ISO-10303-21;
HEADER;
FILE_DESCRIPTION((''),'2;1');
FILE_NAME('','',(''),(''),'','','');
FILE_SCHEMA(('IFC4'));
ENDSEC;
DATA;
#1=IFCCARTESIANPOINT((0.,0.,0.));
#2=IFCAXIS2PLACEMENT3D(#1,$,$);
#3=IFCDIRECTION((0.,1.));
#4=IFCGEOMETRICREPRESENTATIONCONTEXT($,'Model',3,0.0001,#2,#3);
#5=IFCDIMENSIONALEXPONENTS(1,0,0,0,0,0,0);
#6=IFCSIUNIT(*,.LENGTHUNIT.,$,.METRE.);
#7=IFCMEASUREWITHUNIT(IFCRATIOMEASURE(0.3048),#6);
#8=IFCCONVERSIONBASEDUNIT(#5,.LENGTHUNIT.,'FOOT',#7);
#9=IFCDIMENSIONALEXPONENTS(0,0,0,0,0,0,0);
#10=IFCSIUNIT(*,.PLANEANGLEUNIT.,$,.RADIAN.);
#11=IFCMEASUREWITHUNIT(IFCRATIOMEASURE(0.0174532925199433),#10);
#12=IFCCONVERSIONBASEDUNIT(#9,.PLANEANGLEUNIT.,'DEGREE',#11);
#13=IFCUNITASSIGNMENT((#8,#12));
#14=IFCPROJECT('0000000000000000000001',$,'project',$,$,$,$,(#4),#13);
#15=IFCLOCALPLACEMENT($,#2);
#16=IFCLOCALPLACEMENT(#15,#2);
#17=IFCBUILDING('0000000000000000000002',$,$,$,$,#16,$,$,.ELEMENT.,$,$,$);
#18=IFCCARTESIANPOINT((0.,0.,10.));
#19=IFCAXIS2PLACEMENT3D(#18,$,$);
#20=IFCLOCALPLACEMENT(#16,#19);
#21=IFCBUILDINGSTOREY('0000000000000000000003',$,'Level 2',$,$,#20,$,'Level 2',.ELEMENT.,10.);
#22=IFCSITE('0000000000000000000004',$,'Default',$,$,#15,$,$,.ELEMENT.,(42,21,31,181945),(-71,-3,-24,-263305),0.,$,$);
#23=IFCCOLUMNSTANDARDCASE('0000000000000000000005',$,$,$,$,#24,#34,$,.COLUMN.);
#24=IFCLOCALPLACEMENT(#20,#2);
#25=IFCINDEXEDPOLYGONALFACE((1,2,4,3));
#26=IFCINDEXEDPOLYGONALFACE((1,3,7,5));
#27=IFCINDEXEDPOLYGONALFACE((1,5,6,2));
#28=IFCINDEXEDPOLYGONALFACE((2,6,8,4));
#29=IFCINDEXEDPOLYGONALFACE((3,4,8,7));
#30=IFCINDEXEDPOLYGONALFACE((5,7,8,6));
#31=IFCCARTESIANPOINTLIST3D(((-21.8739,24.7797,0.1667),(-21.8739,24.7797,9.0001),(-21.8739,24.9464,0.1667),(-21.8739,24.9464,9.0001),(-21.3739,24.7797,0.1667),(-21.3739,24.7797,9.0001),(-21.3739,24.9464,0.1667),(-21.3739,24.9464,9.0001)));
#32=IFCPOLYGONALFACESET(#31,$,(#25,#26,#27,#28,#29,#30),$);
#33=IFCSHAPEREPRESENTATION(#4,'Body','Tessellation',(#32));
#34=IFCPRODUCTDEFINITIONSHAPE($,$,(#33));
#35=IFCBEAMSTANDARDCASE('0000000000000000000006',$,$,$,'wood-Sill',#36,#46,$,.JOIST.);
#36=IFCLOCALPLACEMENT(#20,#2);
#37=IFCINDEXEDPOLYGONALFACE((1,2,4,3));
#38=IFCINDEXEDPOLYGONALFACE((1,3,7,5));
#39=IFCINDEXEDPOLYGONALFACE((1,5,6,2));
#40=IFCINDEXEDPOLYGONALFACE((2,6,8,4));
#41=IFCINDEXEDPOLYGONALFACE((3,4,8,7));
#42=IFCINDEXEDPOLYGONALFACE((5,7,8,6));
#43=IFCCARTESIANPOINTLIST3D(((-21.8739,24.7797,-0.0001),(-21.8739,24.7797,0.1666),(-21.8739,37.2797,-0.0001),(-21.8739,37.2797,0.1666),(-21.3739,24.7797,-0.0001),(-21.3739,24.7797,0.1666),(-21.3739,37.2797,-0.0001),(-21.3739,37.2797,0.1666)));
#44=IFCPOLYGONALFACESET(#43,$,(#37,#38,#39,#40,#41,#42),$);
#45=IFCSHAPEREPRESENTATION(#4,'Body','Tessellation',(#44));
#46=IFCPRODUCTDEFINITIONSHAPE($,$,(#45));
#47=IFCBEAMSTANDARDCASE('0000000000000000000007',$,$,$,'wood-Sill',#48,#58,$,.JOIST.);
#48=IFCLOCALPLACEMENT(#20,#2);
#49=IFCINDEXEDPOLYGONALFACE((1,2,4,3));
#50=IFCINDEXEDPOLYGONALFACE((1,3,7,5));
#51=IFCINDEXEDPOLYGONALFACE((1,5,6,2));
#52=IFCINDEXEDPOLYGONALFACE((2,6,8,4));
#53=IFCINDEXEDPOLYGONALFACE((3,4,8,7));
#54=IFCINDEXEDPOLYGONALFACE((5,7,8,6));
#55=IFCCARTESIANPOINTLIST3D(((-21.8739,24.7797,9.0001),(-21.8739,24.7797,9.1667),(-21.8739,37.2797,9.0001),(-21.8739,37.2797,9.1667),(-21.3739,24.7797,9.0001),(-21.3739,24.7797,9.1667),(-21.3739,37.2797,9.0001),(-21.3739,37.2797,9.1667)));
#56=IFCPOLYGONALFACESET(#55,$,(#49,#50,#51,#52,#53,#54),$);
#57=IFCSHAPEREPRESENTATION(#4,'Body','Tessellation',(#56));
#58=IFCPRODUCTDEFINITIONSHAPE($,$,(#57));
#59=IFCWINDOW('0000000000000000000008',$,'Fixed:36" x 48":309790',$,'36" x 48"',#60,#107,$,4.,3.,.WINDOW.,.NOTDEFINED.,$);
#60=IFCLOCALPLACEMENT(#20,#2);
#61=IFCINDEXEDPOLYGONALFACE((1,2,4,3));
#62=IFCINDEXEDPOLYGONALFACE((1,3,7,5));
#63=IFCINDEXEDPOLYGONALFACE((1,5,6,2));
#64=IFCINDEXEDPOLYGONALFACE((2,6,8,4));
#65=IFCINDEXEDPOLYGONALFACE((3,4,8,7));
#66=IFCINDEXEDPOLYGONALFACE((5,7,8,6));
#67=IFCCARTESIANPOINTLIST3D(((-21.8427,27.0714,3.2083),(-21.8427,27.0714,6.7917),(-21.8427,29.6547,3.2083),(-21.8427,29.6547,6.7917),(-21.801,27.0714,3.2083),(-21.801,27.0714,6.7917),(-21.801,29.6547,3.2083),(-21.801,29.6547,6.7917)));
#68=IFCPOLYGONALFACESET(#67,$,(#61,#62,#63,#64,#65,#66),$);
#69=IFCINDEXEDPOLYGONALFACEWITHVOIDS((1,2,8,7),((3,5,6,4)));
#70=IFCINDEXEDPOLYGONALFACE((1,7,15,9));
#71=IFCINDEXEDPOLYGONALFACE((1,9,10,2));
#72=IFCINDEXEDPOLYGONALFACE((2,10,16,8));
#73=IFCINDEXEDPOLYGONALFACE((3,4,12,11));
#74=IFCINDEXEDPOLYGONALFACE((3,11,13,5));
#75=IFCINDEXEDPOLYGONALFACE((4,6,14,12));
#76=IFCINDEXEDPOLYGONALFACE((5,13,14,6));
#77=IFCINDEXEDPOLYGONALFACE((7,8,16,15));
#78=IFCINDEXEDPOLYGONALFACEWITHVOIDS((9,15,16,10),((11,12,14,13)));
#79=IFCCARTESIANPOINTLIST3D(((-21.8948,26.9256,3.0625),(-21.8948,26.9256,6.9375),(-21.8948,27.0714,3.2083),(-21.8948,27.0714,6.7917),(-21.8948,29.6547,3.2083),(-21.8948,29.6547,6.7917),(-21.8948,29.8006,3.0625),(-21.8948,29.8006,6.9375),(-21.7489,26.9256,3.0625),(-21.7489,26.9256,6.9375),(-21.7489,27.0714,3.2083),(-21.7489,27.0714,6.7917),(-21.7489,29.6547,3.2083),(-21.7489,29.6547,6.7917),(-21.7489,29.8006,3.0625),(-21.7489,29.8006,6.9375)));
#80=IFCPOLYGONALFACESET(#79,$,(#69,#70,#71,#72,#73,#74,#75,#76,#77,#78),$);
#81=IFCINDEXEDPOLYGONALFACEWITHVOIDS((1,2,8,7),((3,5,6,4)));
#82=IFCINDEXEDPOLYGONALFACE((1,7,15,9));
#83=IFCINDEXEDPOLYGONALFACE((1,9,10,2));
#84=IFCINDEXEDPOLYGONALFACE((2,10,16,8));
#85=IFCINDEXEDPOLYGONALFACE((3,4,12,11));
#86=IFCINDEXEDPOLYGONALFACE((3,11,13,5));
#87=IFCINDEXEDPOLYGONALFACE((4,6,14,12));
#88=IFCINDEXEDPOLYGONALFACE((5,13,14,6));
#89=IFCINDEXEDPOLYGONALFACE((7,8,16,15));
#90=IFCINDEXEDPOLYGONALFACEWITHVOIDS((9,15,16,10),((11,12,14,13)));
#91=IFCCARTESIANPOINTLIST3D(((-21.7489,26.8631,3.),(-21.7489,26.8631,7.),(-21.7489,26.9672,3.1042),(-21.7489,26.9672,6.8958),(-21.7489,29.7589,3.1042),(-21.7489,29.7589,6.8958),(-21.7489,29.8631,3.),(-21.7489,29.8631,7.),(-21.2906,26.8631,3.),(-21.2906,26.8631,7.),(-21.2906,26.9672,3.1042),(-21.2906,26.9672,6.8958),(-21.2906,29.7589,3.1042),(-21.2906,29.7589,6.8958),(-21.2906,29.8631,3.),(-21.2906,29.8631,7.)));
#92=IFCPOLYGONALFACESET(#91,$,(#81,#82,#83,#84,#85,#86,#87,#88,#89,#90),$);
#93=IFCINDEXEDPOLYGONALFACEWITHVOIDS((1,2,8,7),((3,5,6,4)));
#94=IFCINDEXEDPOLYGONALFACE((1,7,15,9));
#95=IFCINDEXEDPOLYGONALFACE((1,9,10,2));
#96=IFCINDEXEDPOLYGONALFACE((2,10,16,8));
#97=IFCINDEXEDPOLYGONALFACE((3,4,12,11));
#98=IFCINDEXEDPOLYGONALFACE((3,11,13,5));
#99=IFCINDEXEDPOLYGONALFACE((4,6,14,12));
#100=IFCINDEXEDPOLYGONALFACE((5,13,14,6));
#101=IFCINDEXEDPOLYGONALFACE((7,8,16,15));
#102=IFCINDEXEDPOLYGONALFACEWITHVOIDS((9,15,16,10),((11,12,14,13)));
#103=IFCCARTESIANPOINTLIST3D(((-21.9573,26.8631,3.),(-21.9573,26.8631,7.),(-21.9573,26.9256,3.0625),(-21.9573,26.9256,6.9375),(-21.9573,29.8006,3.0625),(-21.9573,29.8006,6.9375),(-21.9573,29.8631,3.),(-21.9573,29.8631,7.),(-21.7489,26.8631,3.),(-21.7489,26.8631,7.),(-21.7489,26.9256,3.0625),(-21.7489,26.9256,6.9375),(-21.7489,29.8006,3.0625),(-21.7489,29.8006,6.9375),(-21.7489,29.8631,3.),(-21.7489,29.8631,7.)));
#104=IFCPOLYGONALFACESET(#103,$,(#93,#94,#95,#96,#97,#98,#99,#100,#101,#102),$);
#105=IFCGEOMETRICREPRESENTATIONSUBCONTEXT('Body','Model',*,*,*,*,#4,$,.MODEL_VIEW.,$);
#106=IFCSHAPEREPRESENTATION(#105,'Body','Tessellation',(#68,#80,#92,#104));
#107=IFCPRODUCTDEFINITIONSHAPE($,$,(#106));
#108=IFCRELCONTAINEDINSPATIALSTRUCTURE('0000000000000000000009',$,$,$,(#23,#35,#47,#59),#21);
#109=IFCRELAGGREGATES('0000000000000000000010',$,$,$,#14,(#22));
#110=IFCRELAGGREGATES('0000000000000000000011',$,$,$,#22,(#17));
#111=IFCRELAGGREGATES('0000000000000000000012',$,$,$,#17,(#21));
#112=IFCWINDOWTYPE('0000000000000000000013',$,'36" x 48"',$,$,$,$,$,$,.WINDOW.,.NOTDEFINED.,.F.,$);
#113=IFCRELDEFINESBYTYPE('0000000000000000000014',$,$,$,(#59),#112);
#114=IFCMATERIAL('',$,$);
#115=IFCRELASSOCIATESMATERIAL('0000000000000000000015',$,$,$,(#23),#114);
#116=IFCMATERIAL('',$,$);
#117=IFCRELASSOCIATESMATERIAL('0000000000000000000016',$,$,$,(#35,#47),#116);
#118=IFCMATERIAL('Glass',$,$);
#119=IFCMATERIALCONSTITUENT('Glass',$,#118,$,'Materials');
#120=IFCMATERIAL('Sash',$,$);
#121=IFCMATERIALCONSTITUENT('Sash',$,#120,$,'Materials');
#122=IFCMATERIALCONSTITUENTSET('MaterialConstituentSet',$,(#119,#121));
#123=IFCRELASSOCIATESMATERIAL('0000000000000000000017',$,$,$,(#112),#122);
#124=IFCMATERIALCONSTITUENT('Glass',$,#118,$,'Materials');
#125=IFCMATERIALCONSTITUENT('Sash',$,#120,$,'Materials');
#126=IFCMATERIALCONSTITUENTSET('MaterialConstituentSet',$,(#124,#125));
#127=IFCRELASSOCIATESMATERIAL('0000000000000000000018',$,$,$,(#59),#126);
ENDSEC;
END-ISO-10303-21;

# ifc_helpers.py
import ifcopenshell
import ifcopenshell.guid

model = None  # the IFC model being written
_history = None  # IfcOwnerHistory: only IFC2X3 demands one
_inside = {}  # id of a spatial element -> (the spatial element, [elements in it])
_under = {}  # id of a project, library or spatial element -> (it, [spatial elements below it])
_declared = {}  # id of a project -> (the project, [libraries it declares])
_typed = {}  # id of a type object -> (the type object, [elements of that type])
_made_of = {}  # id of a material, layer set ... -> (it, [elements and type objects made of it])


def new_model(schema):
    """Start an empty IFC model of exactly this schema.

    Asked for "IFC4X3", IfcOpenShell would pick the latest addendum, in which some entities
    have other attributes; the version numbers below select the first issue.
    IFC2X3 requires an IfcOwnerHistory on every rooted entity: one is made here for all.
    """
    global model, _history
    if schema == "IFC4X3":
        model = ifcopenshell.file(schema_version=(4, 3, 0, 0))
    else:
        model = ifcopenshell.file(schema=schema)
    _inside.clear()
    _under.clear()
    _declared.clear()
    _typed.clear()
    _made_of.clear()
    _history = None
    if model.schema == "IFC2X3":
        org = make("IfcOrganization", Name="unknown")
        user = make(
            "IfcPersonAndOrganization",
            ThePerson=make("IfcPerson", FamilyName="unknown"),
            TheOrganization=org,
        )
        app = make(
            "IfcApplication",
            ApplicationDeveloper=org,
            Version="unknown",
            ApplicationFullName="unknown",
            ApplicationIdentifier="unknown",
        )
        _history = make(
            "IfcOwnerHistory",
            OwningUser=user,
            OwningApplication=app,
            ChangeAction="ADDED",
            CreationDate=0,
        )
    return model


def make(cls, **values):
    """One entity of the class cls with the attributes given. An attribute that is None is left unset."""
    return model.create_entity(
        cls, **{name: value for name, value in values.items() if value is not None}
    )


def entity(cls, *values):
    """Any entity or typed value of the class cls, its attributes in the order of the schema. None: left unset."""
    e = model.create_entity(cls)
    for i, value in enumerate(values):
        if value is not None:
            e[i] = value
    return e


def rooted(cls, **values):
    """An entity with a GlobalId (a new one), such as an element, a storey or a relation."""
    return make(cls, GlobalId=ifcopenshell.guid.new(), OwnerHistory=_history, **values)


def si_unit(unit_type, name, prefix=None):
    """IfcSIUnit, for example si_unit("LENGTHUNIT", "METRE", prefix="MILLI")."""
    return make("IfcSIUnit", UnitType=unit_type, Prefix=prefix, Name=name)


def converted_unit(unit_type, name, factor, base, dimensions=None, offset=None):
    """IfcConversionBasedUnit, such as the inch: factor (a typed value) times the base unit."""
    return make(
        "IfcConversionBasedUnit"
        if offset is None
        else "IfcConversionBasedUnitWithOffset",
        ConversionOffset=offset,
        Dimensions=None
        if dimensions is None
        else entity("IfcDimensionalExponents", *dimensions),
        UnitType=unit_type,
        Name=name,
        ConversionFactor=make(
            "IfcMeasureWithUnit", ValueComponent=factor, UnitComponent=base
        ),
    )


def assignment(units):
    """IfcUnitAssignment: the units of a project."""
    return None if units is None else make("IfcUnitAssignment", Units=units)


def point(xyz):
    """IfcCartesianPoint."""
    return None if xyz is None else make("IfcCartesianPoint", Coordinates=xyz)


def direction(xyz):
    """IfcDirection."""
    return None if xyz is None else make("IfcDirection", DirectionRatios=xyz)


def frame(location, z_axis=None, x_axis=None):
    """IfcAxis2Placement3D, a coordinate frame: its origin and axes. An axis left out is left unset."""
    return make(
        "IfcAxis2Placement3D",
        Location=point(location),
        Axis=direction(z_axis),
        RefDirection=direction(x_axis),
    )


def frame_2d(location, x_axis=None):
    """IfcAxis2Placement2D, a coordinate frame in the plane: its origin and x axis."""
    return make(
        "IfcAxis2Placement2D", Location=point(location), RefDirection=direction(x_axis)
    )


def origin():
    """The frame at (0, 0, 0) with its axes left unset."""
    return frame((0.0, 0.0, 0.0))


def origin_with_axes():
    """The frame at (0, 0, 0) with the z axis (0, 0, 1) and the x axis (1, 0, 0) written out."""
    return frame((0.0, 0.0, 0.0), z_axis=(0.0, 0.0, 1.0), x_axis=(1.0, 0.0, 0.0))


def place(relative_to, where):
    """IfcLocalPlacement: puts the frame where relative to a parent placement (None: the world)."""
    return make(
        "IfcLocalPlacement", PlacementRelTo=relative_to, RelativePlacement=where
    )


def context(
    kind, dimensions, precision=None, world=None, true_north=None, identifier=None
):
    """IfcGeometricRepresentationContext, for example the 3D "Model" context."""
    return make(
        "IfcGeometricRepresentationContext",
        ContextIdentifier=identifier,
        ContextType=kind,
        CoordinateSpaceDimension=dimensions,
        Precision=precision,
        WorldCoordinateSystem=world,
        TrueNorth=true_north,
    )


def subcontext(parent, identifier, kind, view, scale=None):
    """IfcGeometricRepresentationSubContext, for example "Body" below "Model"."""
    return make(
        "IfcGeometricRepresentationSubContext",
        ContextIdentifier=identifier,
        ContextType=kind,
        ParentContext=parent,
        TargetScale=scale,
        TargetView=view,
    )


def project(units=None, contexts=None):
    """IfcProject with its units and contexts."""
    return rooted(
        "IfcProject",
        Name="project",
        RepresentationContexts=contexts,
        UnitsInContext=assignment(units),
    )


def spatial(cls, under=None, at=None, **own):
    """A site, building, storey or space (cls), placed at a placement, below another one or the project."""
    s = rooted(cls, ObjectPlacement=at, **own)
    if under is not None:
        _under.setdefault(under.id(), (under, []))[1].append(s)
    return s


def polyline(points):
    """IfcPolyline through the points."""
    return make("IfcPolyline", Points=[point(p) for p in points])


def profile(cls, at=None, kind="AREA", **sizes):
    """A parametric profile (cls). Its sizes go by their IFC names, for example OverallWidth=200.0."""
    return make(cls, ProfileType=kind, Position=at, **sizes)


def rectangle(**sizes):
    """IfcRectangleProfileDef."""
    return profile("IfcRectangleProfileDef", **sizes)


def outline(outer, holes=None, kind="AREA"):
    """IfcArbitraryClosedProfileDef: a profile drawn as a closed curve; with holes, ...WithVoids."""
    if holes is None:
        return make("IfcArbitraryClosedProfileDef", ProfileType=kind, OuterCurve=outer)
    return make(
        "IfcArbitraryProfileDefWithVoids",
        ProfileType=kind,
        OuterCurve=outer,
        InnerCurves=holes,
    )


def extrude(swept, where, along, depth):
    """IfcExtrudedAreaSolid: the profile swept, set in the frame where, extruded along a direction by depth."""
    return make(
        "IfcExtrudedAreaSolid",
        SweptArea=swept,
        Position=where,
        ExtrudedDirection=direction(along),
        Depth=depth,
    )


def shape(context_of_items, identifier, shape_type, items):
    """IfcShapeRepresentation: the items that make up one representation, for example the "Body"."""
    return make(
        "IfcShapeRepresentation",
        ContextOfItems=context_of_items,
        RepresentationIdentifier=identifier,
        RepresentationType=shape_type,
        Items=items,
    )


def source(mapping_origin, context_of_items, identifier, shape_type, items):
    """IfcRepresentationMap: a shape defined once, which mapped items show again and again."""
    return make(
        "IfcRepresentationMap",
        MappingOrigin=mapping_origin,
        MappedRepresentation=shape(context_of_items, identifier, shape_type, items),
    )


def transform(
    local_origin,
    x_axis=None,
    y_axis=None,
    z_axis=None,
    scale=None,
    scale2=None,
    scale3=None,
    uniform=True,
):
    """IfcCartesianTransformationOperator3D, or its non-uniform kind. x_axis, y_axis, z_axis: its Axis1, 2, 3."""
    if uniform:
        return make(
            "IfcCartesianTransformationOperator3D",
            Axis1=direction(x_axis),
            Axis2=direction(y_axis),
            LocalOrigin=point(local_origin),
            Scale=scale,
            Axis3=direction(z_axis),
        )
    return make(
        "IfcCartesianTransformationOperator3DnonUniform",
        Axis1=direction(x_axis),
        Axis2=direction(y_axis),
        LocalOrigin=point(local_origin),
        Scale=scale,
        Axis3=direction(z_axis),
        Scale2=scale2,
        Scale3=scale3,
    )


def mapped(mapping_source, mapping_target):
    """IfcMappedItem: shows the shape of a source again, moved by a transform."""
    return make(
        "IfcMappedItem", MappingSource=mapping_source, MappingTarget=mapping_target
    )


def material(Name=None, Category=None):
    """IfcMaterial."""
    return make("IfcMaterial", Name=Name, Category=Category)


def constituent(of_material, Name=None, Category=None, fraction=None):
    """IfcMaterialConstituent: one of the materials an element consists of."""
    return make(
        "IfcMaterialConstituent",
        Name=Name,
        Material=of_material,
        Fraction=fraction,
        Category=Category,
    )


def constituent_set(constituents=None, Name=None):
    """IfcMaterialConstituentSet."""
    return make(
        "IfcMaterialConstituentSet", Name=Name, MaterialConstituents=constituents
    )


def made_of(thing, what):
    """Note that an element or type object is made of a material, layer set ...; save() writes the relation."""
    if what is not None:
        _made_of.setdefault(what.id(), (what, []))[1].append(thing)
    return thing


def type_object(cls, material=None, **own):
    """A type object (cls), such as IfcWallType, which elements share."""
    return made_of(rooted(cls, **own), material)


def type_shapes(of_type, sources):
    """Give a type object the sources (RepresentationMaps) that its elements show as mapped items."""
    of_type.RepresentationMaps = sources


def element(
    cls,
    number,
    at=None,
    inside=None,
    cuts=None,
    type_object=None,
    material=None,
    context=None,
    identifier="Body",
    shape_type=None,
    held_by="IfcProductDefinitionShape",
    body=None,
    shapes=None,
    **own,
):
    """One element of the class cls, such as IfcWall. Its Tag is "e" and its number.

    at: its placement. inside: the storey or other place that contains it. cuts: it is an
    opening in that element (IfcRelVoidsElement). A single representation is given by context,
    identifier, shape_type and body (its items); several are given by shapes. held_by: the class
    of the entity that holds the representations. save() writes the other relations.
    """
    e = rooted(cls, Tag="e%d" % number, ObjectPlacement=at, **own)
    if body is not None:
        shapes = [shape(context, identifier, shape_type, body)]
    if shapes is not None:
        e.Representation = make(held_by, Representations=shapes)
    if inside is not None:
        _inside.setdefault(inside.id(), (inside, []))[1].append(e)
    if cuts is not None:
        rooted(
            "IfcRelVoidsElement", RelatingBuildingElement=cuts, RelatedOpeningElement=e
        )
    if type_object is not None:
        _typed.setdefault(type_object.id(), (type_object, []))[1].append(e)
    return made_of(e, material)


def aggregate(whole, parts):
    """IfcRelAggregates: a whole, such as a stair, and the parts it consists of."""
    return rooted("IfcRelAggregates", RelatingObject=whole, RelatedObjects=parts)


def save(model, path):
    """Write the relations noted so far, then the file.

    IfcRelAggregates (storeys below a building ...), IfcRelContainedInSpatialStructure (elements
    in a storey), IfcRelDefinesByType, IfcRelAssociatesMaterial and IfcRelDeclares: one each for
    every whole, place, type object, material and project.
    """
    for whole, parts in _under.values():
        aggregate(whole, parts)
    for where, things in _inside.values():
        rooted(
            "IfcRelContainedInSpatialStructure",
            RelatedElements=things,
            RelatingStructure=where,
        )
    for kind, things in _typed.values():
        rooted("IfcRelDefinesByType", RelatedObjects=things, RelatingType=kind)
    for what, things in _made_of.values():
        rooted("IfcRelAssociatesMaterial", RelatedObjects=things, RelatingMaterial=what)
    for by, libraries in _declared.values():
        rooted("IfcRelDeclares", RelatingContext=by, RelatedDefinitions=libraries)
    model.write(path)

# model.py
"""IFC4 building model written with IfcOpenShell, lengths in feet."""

from ifc_helpers import new_model, entity, si_unit, converted_unit, direction, frame, frame_2d, origin, origin_with_axes, place, context, subcontext, project, spatial, polyline, rectangle, outline, extrude, source, transform, mapped, material, constituent, constituent_set, type_object, type_shapes, element, save


model = new_model("IFC4")

# Units and contexts
model_context = context("Model", 3, precision=0.0001, world=origin(), true_north=direction((0.0, 1.0)))
body_context = subcontext(model_context, "Body", "Model", "MODEL_VIEW")
ifc_project = project(units=[converted_unit("LENGTHUNIT", "FOOT", entity("IfcRatioMeasure", 0.3048), si_unit("LENGTHUNIT", "METRE"), dimensions=[1, 0, 0, 0, 0, 0, 0]), converted_unit("PLANEANGLEUNIT", "DEGREE", entity("IfcRatioMeasure", 0.0174532925199433), si_unit("PLANEANGLEUNIT", "RADIAN"), dimensions=[0, 0, 0, 0, 0, 0, 0])], contexts=[model_context])

# Site, building, storey
site_placement = place(None, origin())
site = spatial("IfcSite", under=ifc_project, at=site_placement, Name="Default", CompositionType="ELEMENT", RefLatitude=(42, 21, 31, 181945), RefLongitude=(-71, -3, -24, -263305), RefElevation=0.0)
building_placement = place(site_placement, origin())
building = spatial("IfcBuilding", under=site, at=building_placement, CompositionType="ELEMENT")
storey_placement = place(building_placement, frame((0.0, 0.0, 10.0)))
storey = spatial("IfcBuildingStorey", under=building, at=storey_placement, Name="Level 2", LongName="Level 2", CompositionType="ELEMENT", Elevation=10.0)

# Column
ifc_material_1 = material(Name="")
placement_1 = place(storey_placement, frame((-21.6239, 24.7797, 0.0), z_axis=(0.0, 0.0, 1.0), x_axis=(0.0, 1.0, 0.0)))
for number, where, z_axis, x_axis in (
    (1, (0.0833, 0.0, 0.1667), (0.0, 0.0, 1.0), (1.0, 0.0, 0.0)),
):
    element("IfcColumnStandardCase", number, at=place(placement_1, frame(where, z_axis=z_axis, x_axis=x_axis)), inside=storey, material=ifc_material_1, PredefinedType="COLUMN", context=model_context, shape_type="SweptSolid", body=[
        extrude(rectangle(XDim=0.1667, YDim=0.5), origin(), (0.0, 0.0, 1.0), 8.8334),
    ])

# Beams
ifc_material_2 = material(Name="")
for number, where, z_axis, x_axis in (
    (2, (0.0, 0.0, 0.0833), (1.0, 0.0, 0.0), (0.0, 0.0, 1.0)),
    (3, (0.0, 0.0, 9.0834), (1.0, 0.0, 0.0), (0.0, 0.0, 1.0)),
):
    element("IfcBeamStandardCase", number, at=place(placement_1, frame(where, z_axis=z_axis, x_axis=x_axis)), inside=storey, material=ifc_material_2, ObjectType="wood-Sill", PredefinedType="JOIST", context=model_context, shape_type="SweptSolid", body=[
        extrude(rectangle(XDim=0.1667, YDim=0.5), origin_with_axes(), (0.0, 0.0, 1.0), 12.5),
    ])

# Window
ifc_material_3 = material(Name="Glass")
ifc_constituent_1 = constituent(ifc_material_3, Name="Glass", Category="Materials")
ifc_material_4 = material(Name="Sash")
ifc_constituent_2 = constituent(ifc_material_4, Name="Sash", Category="Materials")
ifc_constituent_set_1 = constituent_set(constituents=[ifc_constituent_1, ifc_constituent_2], Name="MaterialConstituentSet")
ifc_constituent_3 = constituent(ifc_material_3, Name="Glass", Category="Materials")
ifc_constituent_4 = constituent(ifc_material_4, Name="Sash", Category="Materials")
ifc_constituent_set_2 = constituent_set(constituents=[ifc_constituent_3, ifc_constituent_4], Name="MaterialConstituentSet")
window_type = type_object("IfcWindowType", Name="36\" x 48\"", ParameterTakesPrecedence=False, PartitioningType="NOTDEFINED", PredefinedType="WINDOW", material=ifc_constituent_set_2)
shared_shape = source(origin(), body_context, "Body", "SweptSolid", [
    extrude(rectangle(XDim=2.5833, YDim=0.0417, at=frame_2d((0.0, 0.0), x_axis=(1.0, 0.0))), frame((1.75, 0.5312, 0.2083)), (0.0, 0.0, 1.0), 3.5833),
    extrude(outline(polyline([(-1.4375, -1.9375), (1.4375, -1.9375), (1.4375, 1.9375), (-1.4375, 1.9375), (-1.4375, -1.9375)]), holes=[polyline([(-1.2917, -1.7917), (-1.2917, 1.7917), (1.2917, 1.7917), (1.2917, -1.7917), (-1.2917, -1.7917)])]), frame((1.75, 0.6042, 2.0), z_axis=(0.0, -1.0, 0.0), x_axis=(-1.0, 0.0, 0.0)), (0.0, 0.0, 1.0), 0.1458),
    extrude(outline(polyline([(-1.5, -2.0), (1.5, -2.0), (1.5, 2.0), (-1.5, 2.0), (-1.5, -2.0)]), holes=[polyline([(-1.3958, -1.8958), (-1.3958, 1.8958), (1.3958, 1.8958), (1.3958, -1.8958), (-1.3958, -1.8958)])]), frame((1.75, 0.4583, 2.0), z_axis=(0.0, -1.0, 0.0), x_axis=(-1.0, 0.0, 0.0)), (0.0, 0.0, 1.0), 0.4583),
    extrude(outline(polyline([(-2.0, -1.5), (2.0, -1.5), (2.0, 1.5), (-2.0, 1.5), (-2.0, -1.5)]), holes=[polyline([(-1.9375, -1.4375), (-1.9375, 1.4375), (1.9375, 1.4375), (1.9375, -1.4375), (-1.9375, -1.4375)])]), frame((1.75, 0.6667, 2.0), z_axis=(0.0, -1.0, 0.0), x_axis=(0.0, 0.0, -1.0)), (0.0, 0.0, 1.0), 0.2083),
])
type_shapes(window_type, [shared_shape])
placement_2 = place(placement_1, frame((2.0833, -0.3333, 3.0)))
window_placement = place(placement_2, frame((-0.25, 0.0, 0.0)))
element("IfcWindow", 4, at=window_placement, inside=storey, type_object=window_type, material=ifc_constituent_set_1, Name="Fixed:36\" x 48\":309790", ObjectType="36\" x 48\"", OverallHeight=4.0, OverallWidth=3.0, PartitioningType="NOTDEFINED", PredefinedType="WINDOW", context=body_context, shape_type="MappedRepresentation", body=[
    mapped(shared_shape, transform((0.0, 0.0, 0.0), scale=1.0)),
])

save(model, "model.ifc")
